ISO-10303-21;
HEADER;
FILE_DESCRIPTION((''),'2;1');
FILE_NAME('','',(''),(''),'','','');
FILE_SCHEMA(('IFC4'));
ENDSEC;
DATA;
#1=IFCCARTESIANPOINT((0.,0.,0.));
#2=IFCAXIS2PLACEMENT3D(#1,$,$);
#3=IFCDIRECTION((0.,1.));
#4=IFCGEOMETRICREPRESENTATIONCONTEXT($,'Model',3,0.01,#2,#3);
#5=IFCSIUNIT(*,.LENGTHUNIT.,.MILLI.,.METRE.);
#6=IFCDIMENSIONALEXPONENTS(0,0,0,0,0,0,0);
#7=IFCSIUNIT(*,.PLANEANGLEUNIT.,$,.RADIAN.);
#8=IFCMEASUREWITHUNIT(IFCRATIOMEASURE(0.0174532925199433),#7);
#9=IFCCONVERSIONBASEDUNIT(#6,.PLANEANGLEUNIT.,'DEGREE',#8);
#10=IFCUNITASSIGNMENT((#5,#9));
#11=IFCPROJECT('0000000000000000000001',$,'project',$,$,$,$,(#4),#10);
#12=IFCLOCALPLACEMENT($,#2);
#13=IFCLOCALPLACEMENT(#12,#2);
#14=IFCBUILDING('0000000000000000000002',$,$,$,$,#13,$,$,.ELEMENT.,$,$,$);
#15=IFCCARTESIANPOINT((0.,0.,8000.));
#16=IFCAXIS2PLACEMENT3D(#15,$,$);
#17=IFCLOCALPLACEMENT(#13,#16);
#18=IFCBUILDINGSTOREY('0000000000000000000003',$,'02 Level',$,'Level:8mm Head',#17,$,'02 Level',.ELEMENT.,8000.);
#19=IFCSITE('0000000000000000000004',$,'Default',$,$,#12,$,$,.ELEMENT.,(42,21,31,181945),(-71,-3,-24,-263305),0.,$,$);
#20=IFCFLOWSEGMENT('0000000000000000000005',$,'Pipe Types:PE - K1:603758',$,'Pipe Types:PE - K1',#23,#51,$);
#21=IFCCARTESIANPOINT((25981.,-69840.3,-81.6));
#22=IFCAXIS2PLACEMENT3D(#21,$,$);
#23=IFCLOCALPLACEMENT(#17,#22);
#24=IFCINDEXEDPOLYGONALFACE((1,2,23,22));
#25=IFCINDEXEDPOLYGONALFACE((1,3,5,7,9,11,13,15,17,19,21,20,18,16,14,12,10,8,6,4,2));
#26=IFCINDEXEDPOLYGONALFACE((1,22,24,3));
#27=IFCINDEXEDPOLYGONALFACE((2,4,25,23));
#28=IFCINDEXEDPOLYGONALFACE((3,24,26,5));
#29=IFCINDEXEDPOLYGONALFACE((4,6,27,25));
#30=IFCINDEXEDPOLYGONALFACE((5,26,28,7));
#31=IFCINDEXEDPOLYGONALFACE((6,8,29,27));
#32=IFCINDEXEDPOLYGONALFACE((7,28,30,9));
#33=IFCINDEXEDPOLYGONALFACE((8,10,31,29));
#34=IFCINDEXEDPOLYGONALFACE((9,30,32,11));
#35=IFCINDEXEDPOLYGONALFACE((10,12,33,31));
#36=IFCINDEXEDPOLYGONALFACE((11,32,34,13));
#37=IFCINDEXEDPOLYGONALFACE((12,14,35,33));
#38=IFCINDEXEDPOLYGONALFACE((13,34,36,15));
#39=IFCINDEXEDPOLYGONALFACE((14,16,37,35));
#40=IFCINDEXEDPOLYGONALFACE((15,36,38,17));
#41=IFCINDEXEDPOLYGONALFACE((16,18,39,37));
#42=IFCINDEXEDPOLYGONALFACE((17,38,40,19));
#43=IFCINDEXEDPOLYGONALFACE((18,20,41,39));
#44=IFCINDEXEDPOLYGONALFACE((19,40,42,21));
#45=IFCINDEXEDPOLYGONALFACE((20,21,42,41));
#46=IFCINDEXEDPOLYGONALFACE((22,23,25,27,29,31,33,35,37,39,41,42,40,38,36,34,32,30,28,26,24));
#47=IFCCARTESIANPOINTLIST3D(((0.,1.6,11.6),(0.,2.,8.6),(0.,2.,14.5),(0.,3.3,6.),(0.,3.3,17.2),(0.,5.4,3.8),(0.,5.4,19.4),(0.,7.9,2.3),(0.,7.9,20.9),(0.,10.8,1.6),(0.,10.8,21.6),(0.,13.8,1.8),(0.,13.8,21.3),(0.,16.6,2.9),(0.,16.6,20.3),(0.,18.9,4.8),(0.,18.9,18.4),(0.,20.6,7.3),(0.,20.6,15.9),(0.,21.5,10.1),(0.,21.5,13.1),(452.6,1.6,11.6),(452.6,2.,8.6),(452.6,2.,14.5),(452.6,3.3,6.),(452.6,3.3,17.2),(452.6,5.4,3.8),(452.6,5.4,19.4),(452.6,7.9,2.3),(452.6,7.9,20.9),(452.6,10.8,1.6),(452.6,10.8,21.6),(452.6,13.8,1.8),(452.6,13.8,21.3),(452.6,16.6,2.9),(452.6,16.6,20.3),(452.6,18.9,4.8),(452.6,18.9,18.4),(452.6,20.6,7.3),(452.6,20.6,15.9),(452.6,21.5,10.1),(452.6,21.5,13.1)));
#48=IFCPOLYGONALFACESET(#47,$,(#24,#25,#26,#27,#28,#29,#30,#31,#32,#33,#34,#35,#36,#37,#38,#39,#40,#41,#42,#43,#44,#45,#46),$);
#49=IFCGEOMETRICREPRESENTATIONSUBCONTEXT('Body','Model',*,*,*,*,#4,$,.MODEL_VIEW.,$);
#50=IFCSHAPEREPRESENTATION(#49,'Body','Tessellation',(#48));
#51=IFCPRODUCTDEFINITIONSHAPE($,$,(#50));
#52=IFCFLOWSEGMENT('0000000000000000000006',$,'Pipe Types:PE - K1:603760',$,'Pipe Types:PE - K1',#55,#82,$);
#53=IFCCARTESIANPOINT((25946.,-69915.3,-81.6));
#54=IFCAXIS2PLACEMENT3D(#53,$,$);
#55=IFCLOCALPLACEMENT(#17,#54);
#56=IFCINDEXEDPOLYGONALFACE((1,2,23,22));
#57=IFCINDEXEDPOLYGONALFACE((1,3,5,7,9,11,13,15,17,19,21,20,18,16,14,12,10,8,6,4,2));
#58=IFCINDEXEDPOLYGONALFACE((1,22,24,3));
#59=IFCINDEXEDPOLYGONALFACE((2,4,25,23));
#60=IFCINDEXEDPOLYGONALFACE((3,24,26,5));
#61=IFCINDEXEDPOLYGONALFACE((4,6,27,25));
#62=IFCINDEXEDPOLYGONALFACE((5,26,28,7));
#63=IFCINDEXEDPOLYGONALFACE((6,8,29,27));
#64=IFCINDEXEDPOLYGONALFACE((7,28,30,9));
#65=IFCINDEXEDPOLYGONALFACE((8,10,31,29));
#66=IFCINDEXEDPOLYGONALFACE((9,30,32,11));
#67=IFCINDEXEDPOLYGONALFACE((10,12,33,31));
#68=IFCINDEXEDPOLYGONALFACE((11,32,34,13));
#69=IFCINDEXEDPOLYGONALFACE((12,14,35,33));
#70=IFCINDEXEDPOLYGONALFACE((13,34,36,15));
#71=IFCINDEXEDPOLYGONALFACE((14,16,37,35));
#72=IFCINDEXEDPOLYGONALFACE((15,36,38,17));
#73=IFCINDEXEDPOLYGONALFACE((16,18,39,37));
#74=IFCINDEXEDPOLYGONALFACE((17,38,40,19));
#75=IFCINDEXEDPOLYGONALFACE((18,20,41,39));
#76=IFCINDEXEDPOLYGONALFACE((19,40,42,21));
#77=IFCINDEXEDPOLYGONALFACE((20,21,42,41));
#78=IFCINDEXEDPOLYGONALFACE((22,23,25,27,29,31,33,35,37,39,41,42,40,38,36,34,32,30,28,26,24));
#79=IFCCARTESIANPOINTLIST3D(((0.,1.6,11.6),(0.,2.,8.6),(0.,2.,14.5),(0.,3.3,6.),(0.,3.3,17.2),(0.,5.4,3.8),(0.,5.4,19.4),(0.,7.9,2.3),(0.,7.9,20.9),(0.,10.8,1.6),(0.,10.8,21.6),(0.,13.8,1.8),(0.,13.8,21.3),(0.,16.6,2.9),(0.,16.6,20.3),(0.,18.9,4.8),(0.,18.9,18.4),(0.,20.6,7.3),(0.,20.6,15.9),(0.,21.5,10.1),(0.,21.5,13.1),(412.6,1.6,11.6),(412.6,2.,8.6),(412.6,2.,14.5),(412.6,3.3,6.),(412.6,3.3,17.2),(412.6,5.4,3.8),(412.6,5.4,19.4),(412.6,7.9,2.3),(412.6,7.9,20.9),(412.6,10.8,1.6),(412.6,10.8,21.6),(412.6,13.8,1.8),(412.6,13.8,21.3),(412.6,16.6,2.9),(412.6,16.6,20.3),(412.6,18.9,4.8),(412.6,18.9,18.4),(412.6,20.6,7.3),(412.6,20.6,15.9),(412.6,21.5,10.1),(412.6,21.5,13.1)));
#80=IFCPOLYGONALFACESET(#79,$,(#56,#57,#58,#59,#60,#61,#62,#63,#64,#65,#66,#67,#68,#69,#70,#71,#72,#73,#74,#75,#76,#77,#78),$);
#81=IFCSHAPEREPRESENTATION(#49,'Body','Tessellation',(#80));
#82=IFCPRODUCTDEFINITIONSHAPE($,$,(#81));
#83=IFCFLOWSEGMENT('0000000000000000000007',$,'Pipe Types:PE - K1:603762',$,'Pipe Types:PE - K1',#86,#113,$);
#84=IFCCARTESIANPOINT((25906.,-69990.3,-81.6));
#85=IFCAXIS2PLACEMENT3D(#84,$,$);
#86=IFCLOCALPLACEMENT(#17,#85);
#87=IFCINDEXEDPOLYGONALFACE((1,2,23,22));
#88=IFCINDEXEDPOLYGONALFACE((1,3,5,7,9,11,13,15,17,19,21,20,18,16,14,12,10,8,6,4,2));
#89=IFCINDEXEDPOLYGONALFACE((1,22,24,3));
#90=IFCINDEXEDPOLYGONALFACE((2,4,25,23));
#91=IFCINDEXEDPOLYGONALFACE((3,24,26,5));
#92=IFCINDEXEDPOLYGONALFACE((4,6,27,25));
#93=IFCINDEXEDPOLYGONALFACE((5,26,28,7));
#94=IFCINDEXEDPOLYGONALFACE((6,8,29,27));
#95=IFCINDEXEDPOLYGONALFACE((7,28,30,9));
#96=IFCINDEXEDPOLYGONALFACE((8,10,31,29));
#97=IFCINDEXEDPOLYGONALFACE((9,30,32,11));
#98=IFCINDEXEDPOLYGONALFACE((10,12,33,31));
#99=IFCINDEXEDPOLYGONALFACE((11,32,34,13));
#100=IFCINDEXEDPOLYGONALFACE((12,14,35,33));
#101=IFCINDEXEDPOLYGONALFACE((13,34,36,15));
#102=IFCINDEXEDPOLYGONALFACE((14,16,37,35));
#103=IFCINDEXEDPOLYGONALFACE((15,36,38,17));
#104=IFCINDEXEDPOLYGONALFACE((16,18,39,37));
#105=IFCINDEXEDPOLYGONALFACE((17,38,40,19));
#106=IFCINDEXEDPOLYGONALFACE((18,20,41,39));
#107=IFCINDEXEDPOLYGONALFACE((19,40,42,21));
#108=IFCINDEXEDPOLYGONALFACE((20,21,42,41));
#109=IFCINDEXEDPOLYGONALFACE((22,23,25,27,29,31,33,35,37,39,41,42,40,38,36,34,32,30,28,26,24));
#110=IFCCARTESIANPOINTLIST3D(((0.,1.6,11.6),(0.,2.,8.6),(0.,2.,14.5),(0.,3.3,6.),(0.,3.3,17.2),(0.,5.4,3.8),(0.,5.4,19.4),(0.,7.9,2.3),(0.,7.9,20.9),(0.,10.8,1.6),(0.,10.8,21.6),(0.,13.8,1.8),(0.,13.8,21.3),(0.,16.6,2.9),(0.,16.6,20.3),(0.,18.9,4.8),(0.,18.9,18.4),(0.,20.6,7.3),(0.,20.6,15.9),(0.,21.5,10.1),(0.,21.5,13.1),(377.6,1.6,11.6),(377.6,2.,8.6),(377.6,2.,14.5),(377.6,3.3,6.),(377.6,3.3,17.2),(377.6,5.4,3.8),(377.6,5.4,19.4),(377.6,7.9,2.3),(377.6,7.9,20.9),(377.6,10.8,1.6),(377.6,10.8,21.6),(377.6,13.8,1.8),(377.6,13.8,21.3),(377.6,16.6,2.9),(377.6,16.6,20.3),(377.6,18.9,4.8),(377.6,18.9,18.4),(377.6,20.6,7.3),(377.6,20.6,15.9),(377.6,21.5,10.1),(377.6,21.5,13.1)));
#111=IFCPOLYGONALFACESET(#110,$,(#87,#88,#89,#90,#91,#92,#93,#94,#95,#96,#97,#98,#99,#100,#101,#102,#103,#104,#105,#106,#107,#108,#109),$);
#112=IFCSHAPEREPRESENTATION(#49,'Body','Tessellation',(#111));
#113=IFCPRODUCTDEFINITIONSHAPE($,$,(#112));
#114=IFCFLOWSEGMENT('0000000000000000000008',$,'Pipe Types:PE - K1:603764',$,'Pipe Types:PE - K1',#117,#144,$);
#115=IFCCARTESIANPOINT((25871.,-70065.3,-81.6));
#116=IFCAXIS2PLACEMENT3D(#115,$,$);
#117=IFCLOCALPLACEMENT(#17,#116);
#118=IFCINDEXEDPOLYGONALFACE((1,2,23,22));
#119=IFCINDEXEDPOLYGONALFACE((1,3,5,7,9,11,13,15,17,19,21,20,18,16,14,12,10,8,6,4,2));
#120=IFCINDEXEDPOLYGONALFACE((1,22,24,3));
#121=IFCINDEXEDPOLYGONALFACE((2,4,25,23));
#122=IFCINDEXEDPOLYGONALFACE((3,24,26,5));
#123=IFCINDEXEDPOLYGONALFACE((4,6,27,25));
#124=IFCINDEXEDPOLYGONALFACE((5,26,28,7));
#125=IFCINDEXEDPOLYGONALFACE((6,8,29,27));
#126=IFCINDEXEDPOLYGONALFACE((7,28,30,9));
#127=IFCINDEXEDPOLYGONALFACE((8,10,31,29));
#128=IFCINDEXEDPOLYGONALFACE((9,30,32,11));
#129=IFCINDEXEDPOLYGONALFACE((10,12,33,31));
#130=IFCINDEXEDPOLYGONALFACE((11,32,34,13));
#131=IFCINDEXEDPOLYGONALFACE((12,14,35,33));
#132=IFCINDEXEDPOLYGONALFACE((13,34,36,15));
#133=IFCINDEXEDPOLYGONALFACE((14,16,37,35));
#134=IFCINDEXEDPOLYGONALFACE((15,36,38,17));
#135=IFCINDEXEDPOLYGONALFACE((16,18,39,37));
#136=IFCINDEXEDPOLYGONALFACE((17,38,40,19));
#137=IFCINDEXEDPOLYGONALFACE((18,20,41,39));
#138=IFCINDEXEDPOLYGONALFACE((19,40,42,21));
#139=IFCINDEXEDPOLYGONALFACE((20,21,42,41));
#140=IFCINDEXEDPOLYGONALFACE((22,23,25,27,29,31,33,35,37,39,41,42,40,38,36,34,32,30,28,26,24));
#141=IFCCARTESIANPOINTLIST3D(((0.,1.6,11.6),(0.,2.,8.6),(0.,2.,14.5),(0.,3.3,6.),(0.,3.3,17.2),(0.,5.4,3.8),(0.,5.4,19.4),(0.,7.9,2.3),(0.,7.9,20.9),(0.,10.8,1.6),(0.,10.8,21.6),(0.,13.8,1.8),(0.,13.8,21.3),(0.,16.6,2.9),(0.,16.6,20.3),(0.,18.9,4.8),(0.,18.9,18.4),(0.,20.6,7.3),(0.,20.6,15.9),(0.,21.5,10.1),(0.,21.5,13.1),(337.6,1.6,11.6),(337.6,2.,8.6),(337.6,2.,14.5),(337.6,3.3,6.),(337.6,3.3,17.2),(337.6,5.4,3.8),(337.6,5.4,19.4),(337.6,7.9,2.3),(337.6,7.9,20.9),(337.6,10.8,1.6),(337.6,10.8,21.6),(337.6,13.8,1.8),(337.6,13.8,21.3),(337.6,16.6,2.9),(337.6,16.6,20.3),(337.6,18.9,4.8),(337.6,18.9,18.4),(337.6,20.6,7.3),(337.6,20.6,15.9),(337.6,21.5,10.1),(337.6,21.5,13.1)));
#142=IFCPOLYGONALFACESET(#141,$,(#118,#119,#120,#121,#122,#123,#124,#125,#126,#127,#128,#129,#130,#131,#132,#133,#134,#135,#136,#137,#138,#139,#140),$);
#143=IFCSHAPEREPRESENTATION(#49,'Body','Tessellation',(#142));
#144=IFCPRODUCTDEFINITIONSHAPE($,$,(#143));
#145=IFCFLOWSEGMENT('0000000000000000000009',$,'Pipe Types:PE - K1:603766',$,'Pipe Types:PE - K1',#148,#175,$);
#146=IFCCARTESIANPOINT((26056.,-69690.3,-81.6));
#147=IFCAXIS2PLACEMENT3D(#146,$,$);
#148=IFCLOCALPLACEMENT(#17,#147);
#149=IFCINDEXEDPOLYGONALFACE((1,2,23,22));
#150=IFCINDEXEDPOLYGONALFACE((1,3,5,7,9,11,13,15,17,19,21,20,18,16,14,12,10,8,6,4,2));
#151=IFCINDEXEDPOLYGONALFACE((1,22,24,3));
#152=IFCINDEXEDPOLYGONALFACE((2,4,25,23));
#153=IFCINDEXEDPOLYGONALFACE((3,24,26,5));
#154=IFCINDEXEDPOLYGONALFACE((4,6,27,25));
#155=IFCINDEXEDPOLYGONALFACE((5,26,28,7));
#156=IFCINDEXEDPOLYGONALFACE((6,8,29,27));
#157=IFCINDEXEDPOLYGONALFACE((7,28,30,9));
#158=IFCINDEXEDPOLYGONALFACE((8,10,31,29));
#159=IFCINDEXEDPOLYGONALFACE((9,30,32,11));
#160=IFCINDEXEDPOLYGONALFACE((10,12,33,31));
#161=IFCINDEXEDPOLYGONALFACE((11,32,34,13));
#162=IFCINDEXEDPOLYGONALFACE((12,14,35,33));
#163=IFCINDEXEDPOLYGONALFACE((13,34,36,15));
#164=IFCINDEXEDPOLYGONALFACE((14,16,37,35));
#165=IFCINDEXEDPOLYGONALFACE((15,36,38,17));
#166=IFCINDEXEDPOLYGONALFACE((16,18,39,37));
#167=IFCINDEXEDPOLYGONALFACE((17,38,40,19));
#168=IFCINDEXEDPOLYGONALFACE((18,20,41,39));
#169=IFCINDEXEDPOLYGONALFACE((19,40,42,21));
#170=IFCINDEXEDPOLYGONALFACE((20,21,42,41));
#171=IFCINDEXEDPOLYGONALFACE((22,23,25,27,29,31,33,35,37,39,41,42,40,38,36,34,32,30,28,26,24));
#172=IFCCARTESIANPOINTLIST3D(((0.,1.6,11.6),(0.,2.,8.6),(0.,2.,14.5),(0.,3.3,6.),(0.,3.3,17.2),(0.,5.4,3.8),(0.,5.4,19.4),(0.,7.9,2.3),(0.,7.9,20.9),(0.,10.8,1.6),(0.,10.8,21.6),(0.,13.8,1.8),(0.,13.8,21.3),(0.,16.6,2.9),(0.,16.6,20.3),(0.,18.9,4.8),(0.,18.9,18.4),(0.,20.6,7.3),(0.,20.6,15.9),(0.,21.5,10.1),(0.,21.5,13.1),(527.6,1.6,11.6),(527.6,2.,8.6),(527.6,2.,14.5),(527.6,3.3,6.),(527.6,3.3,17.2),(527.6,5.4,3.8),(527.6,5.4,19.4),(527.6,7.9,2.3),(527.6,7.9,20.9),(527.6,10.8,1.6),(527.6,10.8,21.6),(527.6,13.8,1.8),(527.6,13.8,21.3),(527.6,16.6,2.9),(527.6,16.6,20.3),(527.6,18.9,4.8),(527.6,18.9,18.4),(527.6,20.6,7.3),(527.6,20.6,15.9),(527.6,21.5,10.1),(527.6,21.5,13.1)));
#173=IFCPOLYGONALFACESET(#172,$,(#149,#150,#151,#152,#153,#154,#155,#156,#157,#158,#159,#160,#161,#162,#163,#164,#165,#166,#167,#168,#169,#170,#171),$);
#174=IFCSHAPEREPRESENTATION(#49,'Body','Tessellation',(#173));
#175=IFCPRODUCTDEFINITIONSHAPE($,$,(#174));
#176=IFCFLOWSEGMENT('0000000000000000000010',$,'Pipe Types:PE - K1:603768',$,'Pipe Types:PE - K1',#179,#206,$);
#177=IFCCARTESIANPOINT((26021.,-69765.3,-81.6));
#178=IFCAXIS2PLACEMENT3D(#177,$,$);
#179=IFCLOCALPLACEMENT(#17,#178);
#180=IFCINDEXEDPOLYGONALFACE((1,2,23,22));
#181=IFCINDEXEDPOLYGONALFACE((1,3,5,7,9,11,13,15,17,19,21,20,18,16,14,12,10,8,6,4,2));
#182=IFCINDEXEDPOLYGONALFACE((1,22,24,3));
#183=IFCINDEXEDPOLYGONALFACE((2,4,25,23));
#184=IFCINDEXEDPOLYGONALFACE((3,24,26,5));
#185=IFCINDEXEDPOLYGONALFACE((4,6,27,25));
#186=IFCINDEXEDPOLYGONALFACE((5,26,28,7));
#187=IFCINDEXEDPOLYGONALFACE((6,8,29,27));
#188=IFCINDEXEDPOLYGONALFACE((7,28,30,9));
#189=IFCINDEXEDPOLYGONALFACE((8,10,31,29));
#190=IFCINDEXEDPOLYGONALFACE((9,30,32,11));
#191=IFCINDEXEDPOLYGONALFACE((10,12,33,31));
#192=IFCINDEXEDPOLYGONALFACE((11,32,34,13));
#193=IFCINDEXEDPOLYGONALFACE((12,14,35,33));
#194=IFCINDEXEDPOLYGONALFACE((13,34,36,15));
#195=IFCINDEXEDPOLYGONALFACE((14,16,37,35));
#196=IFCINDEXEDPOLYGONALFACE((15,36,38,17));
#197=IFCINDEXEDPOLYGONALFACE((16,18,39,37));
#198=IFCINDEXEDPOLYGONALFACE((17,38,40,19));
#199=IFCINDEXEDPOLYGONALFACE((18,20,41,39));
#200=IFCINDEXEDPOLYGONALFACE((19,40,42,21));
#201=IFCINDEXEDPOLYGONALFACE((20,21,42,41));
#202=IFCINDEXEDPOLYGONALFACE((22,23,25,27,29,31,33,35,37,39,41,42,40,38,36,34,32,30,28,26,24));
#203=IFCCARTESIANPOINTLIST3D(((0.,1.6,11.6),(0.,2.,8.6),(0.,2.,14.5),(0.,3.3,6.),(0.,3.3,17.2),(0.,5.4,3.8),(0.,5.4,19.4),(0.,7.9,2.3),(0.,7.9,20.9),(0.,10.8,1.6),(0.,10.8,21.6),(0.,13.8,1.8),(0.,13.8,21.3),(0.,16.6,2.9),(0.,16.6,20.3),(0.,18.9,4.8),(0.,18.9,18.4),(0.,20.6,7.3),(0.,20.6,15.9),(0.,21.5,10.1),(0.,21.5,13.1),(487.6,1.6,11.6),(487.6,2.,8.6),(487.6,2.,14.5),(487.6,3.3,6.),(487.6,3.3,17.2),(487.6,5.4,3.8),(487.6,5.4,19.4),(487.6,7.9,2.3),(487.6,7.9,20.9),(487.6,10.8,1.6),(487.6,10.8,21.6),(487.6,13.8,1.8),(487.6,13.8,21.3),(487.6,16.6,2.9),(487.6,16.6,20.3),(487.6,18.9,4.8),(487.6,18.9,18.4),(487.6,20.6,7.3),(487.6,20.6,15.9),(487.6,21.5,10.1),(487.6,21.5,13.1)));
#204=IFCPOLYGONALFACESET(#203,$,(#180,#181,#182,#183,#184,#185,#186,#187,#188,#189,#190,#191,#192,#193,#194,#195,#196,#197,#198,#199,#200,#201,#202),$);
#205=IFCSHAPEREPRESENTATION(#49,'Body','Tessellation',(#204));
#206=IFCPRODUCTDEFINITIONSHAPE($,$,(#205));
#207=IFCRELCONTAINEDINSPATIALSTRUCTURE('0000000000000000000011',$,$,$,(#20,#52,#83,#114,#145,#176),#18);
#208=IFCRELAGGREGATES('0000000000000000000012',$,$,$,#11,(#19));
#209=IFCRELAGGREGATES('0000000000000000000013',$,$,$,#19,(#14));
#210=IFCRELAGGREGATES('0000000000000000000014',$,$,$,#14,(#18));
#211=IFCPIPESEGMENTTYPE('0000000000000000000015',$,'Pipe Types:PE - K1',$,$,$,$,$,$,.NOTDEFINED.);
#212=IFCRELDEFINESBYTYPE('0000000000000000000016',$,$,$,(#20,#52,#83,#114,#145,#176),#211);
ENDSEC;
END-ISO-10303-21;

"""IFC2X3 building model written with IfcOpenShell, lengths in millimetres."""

from ifc_helpers import new_model, entity, si_unit, converted_unit, direction, frame, origin, origin_2d_with_axis, place, context, subcontext, project, spatial, circle, extrude, type_object, element, save


model = new_model("IFC2X3")

# Units and contexts
model_context = context("Model", 3, precision=0.01, world=origin(), true_north=direction((0.0, 1.0)))
body_context = subcontext(model_context, "Body", "Model", "MODEL_VIEW")
ifc_project = project(units=[si_unit("LENGTHUNIT", "METRE", prefix="MILLI"), converted_unit("PLANEANGLEUNIT", "DEGREE", entity("IfcRatioMeasure", 0.0174532925199433), si_unit("PLANEANGLEUNIT", "RADIAN"), dimensions=[0, 0, 0, 0, 0, 0, 0])], contexts=[model_context])

# Site, building, storey
site_placement = place(None, origin())
site = spatial("IfcSite", under=ifc_project, at=site_placement, Name="Default", CompositionType="ELEMENT", RefLatitude=(42, 21, 31, 181945), RefLongitude=(-71, -3, -24, -263305), RefElevation=0.0)
building_placement = place(site_placement, origin())
building = spatial("IfcBuilding", under=site, at=building_placement, CompositionType="ELEMENT")
storey_placement = place(building_placement, frame((0.0, 0.0, 8000.0)))
storey = spatial("IfcBuildingStorey", under=building, at=storey_placement, Name="02 Level", ObjectType="Level:8mm Head", LongName="02 Level", CompositionType="ELEMENT", Elevation=8000.0)

# Flow segments
pipe_segment_type = type_object("IfcPipeSegmentType", Name="Pipe Types:PE - K1", PredefinedType="NOTDEFINED")
flow_segment_1_placement = place(storey_placement, frame((25981.0, -69840.3, -81.6)))
element("IfcFlowSegment", 1, at=flow_segment_1_placement, inside=storey, type_object=pipe_segment_type, Name="Pipe Types:PE - K1:603758", ObjectType="Pipe Types:PE - K1", context=body_context, shape_type="SweptSolid", body=[
    extrude(circle(Radius=10.0, at=origin_2d_with_axis()), frame((0.0, 11.6, 11.6), z_axis=(1.0, 0.0, 0.0), x_axis=(0.0, -1.0, 0.0)), (0.0, 0.0, 1.0), 452.6),
])
flow_segment_2_placement = place(storey_placement, frame((25946.0, -69915.3, -81.6)))
element("IfcFlowSegment", 2, at=flow_segment_2_placement, inside=storey, type_object=pipe_segment_type, Name="Pipe Types:PE - K1:603760", ObjectType="Pipe Types:PE - K1", context=body_context, shape_type="SweptSolid", body=[
    extrude(circle(Radius=10.0, at=origin_2d_with_axis()), frame((0.0, 11.6, 11.6), z_axis=(1.0, 0.0, 0.0), x_axis=(0.0, -1.0, 0.0)), (0.0, 0.0, 1.0), 412.6),
])
flow_segment_3_placement = place(storey_placement, frame((25906.0, -69990.3, -81.6)))
element("IfcFlowSegment", 3, at=flow_segment_3_placement, inside=storey, type_object=pipe_segment_type, Name="Pipe Types:PE - K1:603762", ObjectType="Pipe Types:PE - K1", context=body_context, shape_type="SweptSolid", body=[
    extrude(circle(Radius=10.0, at=origin_2d_with_axis()), frame((0.0, 11.6, 11.6), z_axis=(1.0, 0.0, 0.0), x_axis=(0.0, -1.0, 0.0)), (0.0, 0.0, 1.0), 377.6),
])
flow_segment_4_placement = place(storey_placement, frame((25871.0, -70065.3, -81.6)))
element("IfcFlowSegment", 4, at=flow_segment_4_placement, inside=storey, type_object=pipe_segment_type, Name="Pipe Types:PE - K1:603764", ObjectType="Pipe Types:PE - K1", context=body_context, shape_type="SweptSolid", body=[
    extrude(circle(Radius=10.0, at=origin_2d_with_axis()), frame((0.0, 11.6, 11.6), z_axis=(1.0, 0.0, 0.0), x_axis=(0.0, -1.0, 0.0)), (0.0, 0.0, 1.0), 337.6),
])
flow_segment_5_placement = place(storey_placement, frame((26056.0, -69690.3, -81.6)))
element("IfcFlowSegment", 5, at=flow_segment_5_placement, inside=storey, type_object=pipe_segment_type, Name="Pipe Types:PE - K1:603766", ObjectType="Pipe Types:PE - K1", context=body_context, shape_type="SweptSolid", body=[
    extrude(circle(Radius=10.0, at=origin_2d_with_axis()), frame((0.0, 11.6, 11.6), z_axis=(1.0, 0.0, 0.0), x_axis=(0.0, -1.0, 0.0)), (0.0, 0.0, 1.0), 527.6),
])
flow_segment_6_placement = place(storey_placement, frame((26021.0, -69765.3, -81.6)))
element("IfcFlowSegment", 6, at=flow_segment_6_placement, inside=storey, type_object=pipe_segment_type, Name="Pipe Types:PE - K1:603768", ObjectType="Pipe Types:PE - K1", context=body_context, shape_type="SweptSolid", body=[
    extrude(circle(Radius=10.0, at=origin_2d_with_axis()), frame((0.0, 11.6, 11.6), z_axis=(1.0, 0.0, 0.0), x_axis=(0.0, -1.0, 0.0)), (0.0, 0.0, 1.0), 487.6),
])

save(model, "model.ifc")
